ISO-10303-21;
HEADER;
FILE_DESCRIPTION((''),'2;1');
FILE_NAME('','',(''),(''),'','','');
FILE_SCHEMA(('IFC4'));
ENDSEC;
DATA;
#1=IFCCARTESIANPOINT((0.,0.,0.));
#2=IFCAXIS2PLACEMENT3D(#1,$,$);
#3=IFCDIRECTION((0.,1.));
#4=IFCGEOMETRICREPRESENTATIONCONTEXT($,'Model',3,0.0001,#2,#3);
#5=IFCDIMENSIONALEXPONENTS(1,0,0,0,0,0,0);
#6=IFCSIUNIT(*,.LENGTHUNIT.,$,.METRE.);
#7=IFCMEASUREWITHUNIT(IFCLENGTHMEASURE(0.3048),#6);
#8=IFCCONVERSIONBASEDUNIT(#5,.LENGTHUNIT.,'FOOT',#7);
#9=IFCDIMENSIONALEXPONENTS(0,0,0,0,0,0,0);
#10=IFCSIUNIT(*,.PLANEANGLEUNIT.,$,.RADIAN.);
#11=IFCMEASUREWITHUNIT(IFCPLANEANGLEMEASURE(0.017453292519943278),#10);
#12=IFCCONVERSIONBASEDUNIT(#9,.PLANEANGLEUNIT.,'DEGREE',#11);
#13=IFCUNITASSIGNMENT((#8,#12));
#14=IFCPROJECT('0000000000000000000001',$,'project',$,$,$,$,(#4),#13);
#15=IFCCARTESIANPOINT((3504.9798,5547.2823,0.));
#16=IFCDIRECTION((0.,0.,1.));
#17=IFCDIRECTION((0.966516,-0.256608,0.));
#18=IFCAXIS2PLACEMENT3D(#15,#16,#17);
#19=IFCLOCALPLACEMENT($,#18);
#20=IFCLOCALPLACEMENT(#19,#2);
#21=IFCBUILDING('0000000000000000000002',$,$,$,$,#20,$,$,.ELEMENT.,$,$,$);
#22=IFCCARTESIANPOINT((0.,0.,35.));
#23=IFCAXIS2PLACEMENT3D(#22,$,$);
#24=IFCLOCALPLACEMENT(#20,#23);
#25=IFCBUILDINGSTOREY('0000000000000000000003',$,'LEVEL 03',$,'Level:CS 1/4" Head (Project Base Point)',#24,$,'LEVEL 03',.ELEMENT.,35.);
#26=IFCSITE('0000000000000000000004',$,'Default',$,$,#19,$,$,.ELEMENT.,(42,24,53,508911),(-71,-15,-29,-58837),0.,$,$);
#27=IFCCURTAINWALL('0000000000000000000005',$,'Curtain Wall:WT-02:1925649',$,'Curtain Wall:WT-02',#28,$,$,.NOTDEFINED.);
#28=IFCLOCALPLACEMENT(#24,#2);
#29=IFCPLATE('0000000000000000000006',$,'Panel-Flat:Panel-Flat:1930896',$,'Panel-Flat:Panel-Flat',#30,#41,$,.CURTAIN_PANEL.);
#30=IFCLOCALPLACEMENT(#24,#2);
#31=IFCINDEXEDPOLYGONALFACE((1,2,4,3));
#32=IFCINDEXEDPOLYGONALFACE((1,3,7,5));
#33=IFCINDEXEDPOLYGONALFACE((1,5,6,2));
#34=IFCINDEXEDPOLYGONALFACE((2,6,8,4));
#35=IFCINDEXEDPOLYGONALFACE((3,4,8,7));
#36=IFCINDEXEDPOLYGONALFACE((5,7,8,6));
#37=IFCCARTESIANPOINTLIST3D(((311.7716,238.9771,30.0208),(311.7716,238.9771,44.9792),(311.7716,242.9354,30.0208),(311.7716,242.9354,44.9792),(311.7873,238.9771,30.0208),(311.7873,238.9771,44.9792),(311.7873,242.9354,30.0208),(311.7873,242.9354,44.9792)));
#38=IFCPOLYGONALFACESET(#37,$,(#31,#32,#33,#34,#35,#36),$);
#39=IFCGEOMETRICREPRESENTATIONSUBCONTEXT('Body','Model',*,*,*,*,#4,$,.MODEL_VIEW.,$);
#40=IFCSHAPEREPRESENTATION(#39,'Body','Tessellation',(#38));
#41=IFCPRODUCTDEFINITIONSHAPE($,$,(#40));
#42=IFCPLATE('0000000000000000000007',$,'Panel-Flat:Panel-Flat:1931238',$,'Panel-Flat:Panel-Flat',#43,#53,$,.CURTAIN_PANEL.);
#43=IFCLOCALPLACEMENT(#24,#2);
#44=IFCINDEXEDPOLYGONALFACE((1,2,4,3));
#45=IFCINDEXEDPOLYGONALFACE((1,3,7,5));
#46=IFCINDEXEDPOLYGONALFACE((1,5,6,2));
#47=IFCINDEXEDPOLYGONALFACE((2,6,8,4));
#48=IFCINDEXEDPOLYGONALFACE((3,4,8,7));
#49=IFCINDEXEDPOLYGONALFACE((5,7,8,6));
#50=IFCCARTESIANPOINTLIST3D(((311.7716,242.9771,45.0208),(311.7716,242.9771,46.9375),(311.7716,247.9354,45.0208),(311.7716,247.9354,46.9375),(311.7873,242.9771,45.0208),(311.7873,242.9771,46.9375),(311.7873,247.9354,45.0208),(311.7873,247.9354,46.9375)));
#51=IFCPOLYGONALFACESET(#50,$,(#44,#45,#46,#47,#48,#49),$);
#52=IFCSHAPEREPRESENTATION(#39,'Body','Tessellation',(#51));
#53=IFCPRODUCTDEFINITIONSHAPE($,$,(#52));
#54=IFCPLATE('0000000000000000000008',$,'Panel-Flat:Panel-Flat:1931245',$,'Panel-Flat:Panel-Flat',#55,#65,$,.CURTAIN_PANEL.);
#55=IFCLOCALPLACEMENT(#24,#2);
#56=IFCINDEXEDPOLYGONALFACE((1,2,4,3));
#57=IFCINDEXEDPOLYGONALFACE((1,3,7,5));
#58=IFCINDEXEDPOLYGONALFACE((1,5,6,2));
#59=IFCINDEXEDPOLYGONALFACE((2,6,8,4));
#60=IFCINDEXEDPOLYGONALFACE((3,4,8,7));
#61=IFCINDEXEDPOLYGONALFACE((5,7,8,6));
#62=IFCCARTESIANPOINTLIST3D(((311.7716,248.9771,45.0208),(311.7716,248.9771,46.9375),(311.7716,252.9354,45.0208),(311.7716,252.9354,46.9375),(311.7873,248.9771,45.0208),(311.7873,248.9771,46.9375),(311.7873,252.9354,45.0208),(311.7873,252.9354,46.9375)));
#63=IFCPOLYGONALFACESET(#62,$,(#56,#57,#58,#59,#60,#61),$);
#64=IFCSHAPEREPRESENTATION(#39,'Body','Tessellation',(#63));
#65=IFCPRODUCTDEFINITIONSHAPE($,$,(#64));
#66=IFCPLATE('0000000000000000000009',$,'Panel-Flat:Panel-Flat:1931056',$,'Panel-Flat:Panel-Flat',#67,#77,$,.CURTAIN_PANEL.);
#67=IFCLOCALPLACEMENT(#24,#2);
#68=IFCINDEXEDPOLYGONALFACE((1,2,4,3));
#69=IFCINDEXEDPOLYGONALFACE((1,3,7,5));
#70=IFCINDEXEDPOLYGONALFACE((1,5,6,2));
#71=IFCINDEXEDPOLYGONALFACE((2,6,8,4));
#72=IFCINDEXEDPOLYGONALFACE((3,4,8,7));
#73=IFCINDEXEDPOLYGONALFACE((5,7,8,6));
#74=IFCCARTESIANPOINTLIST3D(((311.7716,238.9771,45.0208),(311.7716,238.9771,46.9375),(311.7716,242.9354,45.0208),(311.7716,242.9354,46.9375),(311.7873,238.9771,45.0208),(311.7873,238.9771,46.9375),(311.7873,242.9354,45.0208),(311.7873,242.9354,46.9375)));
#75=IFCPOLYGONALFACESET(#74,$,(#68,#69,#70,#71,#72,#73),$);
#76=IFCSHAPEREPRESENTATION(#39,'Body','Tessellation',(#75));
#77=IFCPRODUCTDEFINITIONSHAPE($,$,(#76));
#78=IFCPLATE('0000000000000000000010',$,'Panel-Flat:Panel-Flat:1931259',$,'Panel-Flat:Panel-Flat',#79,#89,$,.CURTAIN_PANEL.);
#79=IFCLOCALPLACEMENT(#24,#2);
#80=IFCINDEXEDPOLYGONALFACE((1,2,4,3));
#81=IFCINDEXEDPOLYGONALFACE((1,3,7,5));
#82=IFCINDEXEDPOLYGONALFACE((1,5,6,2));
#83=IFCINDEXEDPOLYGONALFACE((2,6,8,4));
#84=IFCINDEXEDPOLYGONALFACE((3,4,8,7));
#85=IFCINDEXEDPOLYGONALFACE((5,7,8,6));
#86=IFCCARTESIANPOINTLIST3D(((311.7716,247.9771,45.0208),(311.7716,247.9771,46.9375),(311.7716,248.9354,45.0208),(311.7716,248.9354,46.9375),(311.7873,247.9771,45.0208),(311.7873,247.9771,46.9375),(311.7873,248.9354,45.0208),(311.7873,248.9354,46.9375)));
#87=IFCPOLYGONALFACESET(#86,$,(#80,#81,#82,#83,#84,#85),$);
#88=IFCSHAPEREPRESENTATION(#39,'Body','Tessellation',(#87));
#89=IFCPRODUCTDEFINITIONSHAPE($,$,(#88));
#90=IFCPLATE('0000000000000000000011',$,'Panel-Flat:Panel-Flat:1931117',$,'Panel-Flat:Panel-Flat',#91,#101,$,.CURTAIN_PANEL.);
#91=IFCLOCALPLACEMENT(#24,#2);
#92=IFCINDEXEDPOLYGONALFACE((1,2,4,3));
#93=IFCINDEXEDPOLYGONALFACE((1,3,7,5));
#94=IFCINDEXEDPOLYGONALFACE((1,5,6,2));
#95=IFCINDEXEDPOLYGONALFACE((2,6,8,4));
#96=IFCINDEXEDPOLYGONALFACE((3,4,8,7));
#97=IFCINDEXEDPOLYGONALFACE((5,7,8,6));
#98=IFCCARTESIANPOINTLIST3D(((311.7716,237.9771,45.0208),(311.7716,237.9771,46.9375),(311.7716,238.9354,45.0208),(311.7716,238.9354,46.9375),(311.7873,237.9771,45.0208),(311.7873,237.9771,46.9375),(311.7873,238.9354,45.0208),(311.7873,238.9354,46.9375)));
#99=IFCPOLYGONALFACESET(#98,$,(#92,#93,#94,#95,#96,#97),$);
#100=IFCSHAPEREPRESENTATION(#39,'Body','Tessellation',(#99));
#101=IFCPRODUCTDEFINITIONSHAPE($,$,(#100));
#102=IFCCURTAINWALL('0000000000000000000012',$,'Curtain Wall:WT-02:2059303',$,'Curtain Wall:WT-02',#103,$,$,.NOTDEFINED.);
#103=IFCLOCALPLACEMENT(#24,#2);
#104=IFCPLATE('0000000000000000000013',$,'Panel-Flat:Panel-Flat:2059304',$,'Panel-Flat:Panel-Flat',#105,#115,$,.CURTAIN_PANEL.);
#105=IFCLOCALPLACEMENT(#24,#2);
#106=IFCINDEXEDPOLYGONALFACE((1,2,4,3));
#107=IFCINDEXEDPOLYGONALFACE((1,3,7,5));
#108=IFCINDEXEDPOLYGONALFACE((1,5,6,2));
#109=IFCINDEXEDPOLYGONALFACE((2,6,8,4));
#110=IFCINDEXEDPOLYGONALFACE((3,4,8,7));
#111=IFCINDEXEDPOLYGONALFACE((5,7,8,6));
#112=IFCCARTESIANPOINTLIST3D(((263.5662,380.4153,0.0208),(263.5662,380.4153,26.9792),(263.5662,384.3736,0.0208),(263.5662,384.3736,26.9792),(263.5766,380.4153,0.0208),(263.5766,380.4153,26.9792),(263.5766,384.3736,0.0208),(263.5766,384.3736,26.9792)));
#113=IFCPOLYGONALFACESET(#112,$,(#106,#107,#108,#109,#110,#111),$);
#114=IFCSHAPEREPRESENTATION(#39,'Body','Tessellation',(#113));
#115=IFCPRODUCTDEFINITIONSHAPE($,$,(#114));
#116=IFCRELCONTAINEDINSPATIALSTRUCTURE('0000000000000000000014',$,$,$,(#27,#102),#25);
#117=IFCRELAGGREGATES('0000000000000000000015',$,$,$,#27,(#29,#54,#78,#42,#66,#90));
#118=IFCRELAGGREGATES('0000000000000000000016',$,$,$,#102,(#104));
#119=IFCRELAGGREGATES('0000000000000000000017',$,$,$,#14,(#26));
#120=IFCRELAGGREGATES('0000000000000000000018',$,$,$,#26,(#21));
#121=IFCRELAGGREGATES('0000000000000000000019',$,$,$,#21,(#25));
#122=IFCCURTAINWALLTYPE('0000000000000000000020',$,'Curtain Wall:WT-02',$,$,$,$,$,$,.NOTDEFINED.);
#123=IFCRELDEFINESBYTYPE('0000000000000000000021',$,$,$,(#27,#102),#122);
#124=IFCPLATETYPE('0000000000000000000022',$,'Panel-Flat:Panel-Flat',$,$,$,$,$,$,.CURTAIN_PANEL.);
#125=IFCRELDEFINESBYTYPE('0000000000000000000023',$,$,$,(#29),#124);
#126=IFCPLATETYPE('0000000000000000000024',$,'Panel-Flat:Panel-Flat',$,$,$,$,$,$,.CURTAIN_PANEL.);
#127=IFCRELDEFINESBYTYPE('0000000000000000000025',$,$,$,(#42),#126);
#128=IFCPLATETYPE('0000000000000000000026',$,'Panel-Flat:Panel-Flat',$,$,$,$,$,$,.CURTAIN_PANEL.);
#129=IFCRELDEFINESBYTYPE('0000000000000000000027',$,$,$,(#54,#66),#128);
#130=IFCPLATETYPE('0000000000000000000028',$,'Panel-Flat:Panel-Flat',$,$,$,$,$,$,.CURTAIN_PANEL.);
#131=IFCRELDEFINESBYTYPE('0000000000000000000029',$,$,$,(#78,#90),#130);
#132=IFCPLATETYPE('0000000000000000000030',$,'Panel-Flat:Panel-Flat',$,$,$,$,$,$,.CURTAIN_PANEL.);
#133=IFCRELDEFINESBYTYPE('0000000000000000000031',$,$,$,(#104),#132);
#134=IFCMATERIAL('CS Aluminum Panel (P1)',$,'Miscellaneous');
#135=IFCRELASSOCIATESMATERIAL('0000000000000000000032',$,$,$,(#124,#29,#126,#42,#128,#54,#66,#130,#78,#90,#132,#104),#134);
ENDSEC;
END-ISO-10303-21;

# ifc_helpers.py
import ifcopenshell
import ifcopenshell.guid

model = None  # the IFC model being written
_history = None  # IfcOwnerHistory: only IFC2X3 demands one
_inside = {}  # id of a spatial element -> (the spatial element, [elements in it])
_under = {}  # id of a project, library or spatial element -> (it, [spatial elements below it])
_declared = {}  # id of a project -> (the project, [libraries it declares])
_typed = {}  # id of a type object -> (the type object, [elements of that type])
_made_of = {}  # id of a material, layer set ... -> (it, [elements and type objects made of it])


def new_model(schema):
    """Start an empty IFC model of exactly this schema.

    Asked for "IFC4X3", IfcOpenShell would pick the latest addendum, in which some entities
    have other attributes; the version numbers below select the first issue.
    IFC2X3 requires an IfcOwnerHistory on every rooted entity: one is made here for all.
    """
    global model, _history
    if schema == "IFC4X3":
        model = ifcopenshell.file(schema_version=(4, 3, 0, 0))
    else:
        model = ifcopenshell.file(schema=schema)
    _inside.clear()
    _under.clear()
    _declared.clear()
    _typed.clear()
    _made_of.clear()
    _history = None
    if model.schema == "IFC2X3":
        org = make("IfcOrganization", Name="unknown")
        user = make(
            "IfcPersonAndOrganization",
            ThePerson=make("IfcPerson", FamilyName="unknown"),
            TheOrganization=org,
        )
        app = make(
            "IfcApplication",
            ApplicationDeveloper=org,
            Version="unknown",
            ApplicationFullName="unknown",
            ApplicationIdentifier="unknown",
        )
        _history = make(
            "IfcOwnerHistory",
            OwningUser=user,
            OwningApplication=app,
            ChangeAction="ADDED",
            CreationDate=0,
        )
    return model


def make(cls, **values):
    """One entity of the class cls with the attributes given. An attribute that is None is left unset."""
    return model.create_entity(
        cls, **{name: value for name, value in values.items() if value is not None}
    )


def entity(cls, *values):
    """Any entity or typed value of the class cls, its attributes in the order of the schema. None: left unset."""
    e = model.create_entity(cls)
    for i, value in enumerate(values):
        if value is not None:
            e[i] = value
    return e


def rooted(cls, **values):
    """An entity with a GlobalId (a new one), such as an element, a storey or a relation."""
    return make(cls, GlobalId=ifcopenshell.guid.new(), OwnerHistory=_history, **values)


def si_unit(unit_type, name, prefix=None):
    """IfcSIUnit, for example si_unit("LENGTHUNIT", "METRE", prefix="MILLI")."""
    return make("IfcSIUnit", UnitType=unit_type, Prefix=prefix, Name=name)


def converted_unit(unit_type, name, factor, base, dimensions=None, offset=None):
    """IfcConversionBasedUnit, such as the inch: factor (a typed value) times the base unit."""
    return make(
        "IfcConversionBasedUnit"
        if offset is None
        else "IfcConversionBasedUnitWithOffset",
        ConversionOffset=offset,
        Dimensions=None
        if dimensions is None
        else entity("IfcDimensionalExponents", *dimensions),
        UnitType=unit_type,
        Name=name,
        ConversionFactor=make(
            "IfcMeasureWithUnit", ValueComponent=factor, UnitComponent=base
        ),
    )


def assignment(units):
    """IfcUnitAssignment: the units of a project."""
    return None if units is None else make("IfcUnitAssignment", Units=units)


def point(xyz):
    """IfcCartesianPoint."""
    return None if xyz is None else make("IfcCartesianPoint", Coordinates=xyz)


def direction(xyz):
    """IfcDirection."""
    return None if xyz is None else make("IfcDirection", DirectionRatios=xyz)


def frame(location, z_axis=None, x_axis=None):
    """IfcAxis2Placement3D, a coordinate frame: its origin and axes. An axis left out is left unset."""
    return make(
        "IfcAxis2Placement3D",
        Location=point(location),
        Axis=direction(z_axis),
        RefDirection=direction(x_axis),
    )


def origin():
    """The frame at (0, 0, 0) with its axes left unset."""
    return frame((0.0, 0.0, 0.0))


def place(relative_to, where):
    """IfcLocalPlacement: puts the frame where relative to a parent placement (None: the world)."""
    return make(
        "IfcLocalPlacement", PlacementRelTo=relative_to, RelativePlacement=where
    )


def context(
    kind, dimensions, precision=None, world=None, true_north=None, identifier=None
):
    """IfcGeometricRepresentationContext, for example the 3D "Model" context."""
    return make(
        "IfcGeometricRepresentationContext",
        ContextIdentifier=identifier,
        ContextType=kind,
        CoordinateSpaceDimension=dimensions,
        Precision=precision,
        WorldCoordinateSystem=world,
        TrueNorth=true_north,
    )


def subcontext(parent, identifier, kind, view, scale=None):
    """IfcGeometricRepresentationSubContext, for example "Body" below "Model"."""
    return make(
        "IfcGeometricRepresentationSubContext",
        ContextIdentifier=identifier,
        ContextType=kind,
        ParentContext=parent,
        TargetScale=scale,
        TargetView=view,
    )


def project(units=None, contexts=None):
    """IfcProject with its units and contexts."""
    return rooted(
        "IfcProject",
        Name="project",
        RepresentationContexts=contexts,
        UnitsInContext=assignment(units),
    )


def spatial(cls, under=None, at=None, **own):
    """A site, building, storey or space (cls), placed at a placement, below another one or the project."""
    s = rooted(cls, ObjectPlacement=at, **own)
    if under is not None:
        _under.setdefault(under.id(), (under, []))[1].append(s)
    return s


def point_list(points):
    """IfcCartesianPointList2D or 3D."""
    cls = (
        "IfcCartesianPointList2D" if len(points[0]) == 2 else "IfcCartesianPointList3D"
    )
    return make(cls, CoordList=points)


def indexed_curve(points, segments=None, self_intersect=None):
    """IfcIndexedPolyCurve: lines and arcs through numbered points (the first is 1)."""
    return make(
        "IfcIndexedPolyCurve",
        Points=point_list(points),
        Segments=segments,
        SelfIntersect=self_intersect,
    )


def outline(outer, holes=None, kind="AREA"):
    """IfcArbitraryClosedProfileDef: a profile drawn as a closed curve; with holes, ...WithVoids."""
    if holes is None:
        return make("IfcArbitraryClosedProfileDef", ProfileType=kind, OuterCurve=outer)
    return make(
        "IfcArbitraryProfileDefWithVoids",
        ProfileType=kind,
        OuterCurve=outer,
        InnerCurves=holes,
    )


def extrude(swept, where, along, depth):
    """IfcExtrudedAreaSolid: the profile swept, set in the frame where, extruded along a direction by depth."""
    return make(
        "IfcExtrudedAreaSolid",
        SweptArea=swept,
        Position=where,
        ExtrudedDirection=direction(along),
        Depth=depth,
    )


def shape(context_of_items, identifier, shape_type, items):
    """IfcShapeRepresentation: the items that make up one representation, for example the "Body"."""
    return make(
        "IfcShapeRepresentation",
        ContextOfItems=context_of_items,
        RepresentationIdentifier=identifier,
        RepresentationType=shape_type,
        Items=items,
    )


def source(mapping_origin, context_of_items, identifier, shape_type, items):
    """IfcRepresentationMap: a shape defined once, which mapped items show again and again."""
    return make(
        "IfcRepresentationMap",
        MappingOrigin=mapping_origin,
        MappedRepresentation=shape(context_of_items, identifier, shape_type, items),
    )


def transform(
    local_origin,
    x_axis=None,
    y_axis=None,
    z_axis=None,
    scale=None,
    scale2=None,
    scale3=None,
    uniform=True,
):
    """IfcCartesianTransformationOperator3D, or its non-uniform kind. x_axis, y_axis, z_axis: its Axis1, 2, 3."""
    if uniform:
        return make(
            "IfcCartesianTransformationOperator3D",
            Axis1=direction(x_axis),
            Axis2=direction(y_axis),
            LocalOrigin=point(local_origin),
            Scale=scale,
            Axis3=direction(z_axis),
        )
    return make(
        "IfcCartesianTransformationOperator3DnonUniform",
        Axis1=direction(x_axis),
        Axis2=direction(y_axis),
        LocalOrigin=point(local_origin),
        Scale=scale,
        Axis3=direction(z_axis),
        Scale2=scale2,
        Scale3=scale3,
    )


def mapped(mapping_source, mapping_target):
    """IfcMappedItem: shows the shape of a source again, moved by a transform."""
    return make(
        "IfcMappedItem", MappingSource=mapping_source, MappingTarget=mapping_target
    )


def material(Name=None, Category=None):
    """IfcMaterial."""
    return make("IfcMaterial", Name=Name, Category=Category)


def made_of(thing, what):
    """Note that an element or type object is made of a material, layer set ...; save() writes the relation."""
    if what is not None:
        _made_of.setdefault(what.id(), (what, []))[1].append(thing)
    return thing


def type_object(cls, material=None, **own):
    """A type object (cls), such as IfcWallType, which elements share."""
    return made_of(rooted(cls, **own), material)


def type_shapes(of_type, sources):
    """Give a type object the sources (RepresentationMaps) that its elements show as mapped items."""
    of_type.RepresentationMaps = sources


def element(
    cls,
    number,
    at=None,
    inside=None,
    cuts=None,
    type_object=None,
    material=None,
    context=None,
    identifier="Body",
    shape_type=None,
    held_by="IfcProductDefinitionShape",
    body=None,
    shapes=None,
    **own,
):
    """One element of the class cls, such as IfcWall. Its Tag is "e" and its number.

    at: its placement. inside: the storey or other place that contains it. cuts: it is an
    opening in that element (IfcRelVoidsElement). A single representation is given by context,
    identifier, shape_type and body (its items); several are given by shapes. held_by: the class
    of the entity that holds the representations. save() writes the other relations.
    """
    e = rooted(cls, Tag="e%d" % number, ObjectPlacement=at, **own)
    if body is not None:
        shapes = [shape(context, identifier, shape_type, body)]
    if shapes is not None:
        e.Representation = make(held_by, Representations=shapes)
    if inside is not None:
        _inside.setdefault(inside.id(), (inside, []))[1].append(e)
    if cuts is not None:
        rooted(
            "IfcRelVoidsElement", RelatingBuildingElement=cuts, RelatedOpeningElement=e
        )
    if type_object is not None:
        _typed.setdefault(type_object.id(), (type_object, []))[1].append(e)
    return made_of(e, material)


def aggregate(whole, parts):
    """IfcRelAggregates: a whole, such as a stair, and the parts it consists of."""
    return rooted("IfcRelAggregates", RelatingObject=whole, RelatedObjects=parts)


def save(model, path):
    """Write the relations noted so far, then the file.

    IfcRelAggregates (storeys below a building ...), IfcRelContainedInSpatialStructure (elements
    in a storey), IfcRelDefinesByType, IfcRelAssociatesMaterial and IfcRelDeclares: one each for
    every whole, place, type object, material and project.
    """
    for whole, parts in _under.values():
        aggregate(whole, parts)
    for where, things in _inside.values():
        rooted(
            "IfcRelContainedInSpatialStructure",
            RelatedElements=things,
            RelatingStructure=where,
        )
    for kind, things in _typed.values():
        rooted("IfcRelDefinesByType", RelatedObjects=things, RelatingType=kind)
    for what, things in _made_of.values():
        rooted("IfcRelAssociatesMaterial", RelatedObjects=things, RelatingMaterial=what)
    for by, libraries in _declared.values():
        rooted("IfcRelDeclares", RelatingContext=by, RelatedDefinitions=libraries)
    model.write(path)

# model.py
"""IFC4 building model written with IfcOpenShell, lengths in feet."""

from ifc_helpers import new_model, entity, si_unit, converted_unit, direction, frame, origin, place, context, subcontext, project, spatial, indexed_curve, outline, extrude, source, transform, mapped, material, type_object, type_shapes, element, aggregate, save


model = new_model("IFC4")

# Units and contexts
model_context = context("Model", 3, precision=0.0001, world=origin(), true_north=direction((0.0, 1.0)))
body_context = subcontext(model_context, "Body", "Model", "MODEL_VIEW")
ifc_project = project(units=[converted_unit("LENGTHUNIT", "FOOT", entity("IfcLengthMeasure", 0.3048), si_unit("LENGTHUNIT", "METRE"), dimensions=[1, 0, 0, 0, 0, 0, 0]), converted_unit("PLANEANGLEUNIT", "DEGREE", entity("IfcPlaneAngleMeasure", 0.017453292519943278), si_unit("PLANEANGLEUNIT", "RADIAN"), dimensions=[0, 0, 0, 0, 0, 0, 0])], contexts=[model_context])

# Site, building, storey
site_placement = place(None, frame((3504.9798, 5547.2823, 0.0), z_axis=(0.0, 0.0, 1.0), x_axis=(0.966516, -0.256608, 0.0)))
site = spatial("IfcSite", under=ifc_project, at=site_placement, Name="Default", CompositionType="ELEMENT", RefLatitude=(42, 24, 53, 508911), RefLongitude=(-71, -15, -29, -58837), RefElevation=0.0)
building_placement = place(site_placement, origin())
building = spatial("IfcBuilding", under=site, at=building_placement, CompositionType="ELEMENT")
storey_placement = place(building_placement, frame((0.0, 0.0, 35.0)))
storey = spatial("IfcBuildingStorey", under=building, at=storey_placement, Name="LEVEL 03", ObjectType="Level:CS 1/4\" Head (Project Base Point)", LongName="LEVEL 03", CompositionType="ELEMENT", Elevation=35.0)

# Curtain wall, plates
curtain_wall_type = type_object("IfcCurtainWallType", Name="Curtain Wall:WT-02", PredefinedType="NOTDEFINED")
curtain_wall_1_placement = place(storey_placement, frame((0.0, 0.0, -35.0)))
curtain_wall_1 = element("IfcCurtainWall", 1, at=curtain_wall_1_placement, inside=storey, type_object=curtain_wall_type, Name="Curtain Wall:WT-02:1925649", ObjectType="Curtain Wall:WT-02", PredefinedType="NOTDEFINED")
ifc_material_1 = material(Name="CS Aluminum Panel (P1)", Category="Miscellaneous")
plate_type_1 = type_object("IfcPlateType", Name="Panel-Flat:Panel-Flat", PredefinedType="CURTAIN_PANEL", material=ifc_material_1)
shared_shape_1 = source(origin(), body_context, "Body", "SweptSolid", [
    extrude(outline(indexed_curve([(-0.0078, -1.9792), (0.0078, -1.9792), (0.0078, 1.9792), (-0.0078, 1.9792), (-0.0078, -1.9792)], self_intersect=False)), frame((1.9792, 0.0078, 0.0), z_axis=(0.0, 0.0, 1.0), x_axis=(0.0, -1.0, 0.0)), (0.0, 0.0, 1.0), 14.9583),
])
type_shapes(plate_type_1, [shared_shape_1])
plate_1_placement = place(curtain_wall_1_placement, frame((311.7716, 242.9354, 65.0208), z_axis=(0.0, 0.0, 1.0), x_axis=(0.0, -1.0, 0.0)))
plate_1 = element("IfcPlate", 2, at=plate_1_placement, type_object=plate_type_1, material=ifc_material_1, Name="Panel-Flat:Panel-Flat:1930896", ObjectType="Panel-Flat:Panel-Flat", PredefinedType="CURTAIN_PANEL", context=body_context, shape_type="MappedRepresentation", body=[
    mapped(shared_shape_1, transform((0.0, 0.0, 0.0), scale=1.0)),
])
plate_type_2 = type_object("IfcPlateType", Name="Panel-Flat:Panel-Flat", PredefinedType="CURTAIN_PANEL", material=ifc_material_1)
shared_shape_2 = source(origin(), body_context, "Body", "SweptSolid", [
    extrude(outline(indexed_curve([(-0.0078, -2.4792), (0.0078, -2.4792), (0.0078, 2.4792), (-0.0078, 2.4792), (-0.0078, -2.4792)], self_intersect=False)), frame((2.4792, 0.0078, 0.0), z_axis=(0.0, 0.0, 1.0), x_axis=(0.0, -1.0, 0.0)), (0.0, 0.0, 1.0), 1.9167),
])
type_shapes(plate_type_2, [shared_shape_2])
plate_2_placement = place(curtain_wall_1_placement, frame((311.7716, 247.9354, 80.0208), z_axis=(0.0, 0.0, 1.0), x_axis=(0.0, -1.0, 0.0)))
plate_2 = element("IfcPlate", 3, at=plate_2_placement, type_object=plate_type_2, material=ifc_material_1, Name="Panel-Flat:Panel-Flat:1931238", ObjectType="Panel-Flat:Panel-Flat", PredefinedType="CURTAIN_PANEL", context=body_context, shape_type="MappedRepresentation", body=[
    mapped(shared_shape_2, transform((0.0, 0.0, 0.0), scale=1.0)),
])
plate_type_3 = type_object("IfcPlateType", Name="Panel-Flat:Panel-Flat", PredefinedType="CURTAIN_PANEL", material=ifc_material_1)
shared_shape_3 = source(origin(), body_context, "Body", "SweptSolid", [
    extrude(outline(indexed_curve([(-0.0078, -1.9792), (0.0078, -1.9792), (0.0078, 1.9792), (-0.0078, 1.9792), (-0.0078, -1.9792)], self_intersect=False)), frame((1.9792, 0.0078, 0.0), z_axis=(0.0, 0.0, 1.0), x_axis=(0.0, -1.0, 0.0)), (0.0, 0.0, 1.0), 1.9167),
])
type_shapes(plate_type_3, [shared_shape_3])
plate_3_placement = place(curtain_wall_1_placement, frame((311.7716, 252.9354, 80.0208), z_axis=(0.0, 0.0, 1.0), x_axis=(0.0, -1.0, 0.0)))
plate_3 = element("IfcPlate", 4, at=plate_3_placement, type_object=plate_type_3, material=ifc_material_1, Name="Panel-Flat:Panel-Flat:1931245", ObjectType="Panel-Flat:Panel-Flat", PredefinedType="CURTAIN_PANEL", context=body_context, shape_type="MappedRepresentation", body=[
    mapped(shared_shape_3, transform((0.0, 0.0, 0.0), scale=1.0)),
])
plate_4_placement = place(curtain_wall_1_placement, frame((311.7716, 242.9354, 80.0208), z_axis=(0.0, 0.0, 1.0), x_axis=(0.0, -1.0, 0.0)))
plate_4 = element("IfcPlate", 5, at=plate_4_placement, type_object=plate_type_3, material=ifc_material_1, Name="Panel-Flat:Panel-Flat:1931056", ObjectType="Panel-Flat:Panel-Flat", PredefinedType="CURTAIN_PANEL", context=body_context, shape_type="MappedRepresentation", body=[
    mapped(shared_shape_3, transform((0.0, 0.0, 0.0), scale=1.0)),
])
plate_type_4 = type_object("IfcPlateType", Name="Panel-Flat:Panel-Flat", PredefinedType="CURTAIN_PANEL", material=ifc_material_1)
shared_shape_4 = source(origin(), body_context, "Body", "SweptSolid", [
    extrude(outline(indexed_curve([(-0.0078, -0.4792), (0.0078, -0.4792), (0.0078, 0.4792), (-0.0078, 0.4792), (-0.0078, -0.4792)], self_intersect=False)), frame((0.4792, 0.0078, 0.0), z_axis=(0.0, 0.0, 1.0), x_axis=(0.0, -1.0, 0.0)), (0.0, 0.0, 1.0), 1.9167),
])
type_shapes(plate_type_4, [shared_shape_4])
plate_5_placement = place(curtain_wall_1_placement, frame((311.7716, 248.9354, 80.0208), z_axis=(0.0, 0.0, 1.0), x_axis=(0.0, -1.0, 0.0)))
plate_5 = element("IfcPlate", 6, at=plate_5_placement, type_object=plate_type_4, material=ifc_material_1, Name="Panel-Flat:Panel-Flat:1931259", ObjectType="Panel-Flat:Panel-Flat", PredefinedType="CURTAIN_PANEL", context=body_context, shape_type="MappedRepresentation", body=[
    mapped(shared_shape_4, transform((0.0, 0.0, 0.0), scale=1.0)),
])
plate_6_placement = place(curtain_wall_1_placement, frame((311.7716, 238.9354, 80.0208), z_axis=(0.0, 0.0, 1.0), x_axis=(0.0, -1.0, 0.0)))
plate_6 = element("IfcPlate", 7, at=plate_6_placement, type_object=plate_type_4, material=ifc_material_1, Name="Panel-Flat:Panel-Flat:1931117", ObjectType="Panel-Flat:Panel-Flat", PredefinedType="CURTAIN_PANEL", context=body_context, shape_type="MappedRepresentation", body=[
    mapped(shared_shape_4, transform((0.0, 0.0, 0.0), scale=1.0)),
])
aggregate(curtain_wall_1, [plate_1, plate_3, plate_5, plate_2, plate_4, plate_6])

# Curtain wall, plate
curtain_wall_2_placement = place(storey_placement, frame((0.0, 0.0, -35.0)))
curtain_wall_2 = element("IfcCurtainWall", 8, at=curtain_wall_2_placement, inside=storey, type_object=curtain_wall_type, Name="Curtain Wall:WT-02:2059303", ObjectType="Curtain Wall:WT-02", PredefinedType="NOTDEFINED")
plate_type_5 = type_object("IfcPlateType", Name="Panel-Flat:Panel-Flat", PredefinedType="CURTAIN_PANEL", material=ifc_material_1)
shared_shape_5 = source(origin(), body_context, "Body", "SweptSolid", [
    extrude(outline(indexed_curve([(-0.0052, -1.9792), (0.0052, -1.9792), (0.0052, 1.9792), (-0.0052, 1.9792), (-0.0052, -1.9792)], self_intersect=False)), frame((1.9792, 0.0052, 0.0), z_axis=(0.0, 0.0, 1.0), x_axis=(0.0, -1.0, 0.0)), (0.0, 0.0, 1.0), 26.9583),
])
type_shapes(plate_type_5, [shared_shape_5])
plate_7_placement = place(curtain_wall_2_placement, frame((263.5662, 384.3736, 35.0208), z_axis=(0.0, 0.0, 1.0), x_axis=(0.0, -1.0, 0.0)))
plate_7 = element("IfcPlate", 9, at=plate_7_placement, type_object=plate_type_5, material=ifc_material_1, Name="Panel-Flat:Panel-Flat:2059304", ObjectType="Panel-Flat:Panel-Flat", PredefinedType="CURTAIN_PANEL", context=body_context, shape_type="MappedRepresentation", body=[
    mapped(shared_shape_5, transform((0.0, 0.0, 0.0), scale=1.0)),
])
aggregate(curtain_wall_2, [plate_7])

save(model, "model.ifc")
